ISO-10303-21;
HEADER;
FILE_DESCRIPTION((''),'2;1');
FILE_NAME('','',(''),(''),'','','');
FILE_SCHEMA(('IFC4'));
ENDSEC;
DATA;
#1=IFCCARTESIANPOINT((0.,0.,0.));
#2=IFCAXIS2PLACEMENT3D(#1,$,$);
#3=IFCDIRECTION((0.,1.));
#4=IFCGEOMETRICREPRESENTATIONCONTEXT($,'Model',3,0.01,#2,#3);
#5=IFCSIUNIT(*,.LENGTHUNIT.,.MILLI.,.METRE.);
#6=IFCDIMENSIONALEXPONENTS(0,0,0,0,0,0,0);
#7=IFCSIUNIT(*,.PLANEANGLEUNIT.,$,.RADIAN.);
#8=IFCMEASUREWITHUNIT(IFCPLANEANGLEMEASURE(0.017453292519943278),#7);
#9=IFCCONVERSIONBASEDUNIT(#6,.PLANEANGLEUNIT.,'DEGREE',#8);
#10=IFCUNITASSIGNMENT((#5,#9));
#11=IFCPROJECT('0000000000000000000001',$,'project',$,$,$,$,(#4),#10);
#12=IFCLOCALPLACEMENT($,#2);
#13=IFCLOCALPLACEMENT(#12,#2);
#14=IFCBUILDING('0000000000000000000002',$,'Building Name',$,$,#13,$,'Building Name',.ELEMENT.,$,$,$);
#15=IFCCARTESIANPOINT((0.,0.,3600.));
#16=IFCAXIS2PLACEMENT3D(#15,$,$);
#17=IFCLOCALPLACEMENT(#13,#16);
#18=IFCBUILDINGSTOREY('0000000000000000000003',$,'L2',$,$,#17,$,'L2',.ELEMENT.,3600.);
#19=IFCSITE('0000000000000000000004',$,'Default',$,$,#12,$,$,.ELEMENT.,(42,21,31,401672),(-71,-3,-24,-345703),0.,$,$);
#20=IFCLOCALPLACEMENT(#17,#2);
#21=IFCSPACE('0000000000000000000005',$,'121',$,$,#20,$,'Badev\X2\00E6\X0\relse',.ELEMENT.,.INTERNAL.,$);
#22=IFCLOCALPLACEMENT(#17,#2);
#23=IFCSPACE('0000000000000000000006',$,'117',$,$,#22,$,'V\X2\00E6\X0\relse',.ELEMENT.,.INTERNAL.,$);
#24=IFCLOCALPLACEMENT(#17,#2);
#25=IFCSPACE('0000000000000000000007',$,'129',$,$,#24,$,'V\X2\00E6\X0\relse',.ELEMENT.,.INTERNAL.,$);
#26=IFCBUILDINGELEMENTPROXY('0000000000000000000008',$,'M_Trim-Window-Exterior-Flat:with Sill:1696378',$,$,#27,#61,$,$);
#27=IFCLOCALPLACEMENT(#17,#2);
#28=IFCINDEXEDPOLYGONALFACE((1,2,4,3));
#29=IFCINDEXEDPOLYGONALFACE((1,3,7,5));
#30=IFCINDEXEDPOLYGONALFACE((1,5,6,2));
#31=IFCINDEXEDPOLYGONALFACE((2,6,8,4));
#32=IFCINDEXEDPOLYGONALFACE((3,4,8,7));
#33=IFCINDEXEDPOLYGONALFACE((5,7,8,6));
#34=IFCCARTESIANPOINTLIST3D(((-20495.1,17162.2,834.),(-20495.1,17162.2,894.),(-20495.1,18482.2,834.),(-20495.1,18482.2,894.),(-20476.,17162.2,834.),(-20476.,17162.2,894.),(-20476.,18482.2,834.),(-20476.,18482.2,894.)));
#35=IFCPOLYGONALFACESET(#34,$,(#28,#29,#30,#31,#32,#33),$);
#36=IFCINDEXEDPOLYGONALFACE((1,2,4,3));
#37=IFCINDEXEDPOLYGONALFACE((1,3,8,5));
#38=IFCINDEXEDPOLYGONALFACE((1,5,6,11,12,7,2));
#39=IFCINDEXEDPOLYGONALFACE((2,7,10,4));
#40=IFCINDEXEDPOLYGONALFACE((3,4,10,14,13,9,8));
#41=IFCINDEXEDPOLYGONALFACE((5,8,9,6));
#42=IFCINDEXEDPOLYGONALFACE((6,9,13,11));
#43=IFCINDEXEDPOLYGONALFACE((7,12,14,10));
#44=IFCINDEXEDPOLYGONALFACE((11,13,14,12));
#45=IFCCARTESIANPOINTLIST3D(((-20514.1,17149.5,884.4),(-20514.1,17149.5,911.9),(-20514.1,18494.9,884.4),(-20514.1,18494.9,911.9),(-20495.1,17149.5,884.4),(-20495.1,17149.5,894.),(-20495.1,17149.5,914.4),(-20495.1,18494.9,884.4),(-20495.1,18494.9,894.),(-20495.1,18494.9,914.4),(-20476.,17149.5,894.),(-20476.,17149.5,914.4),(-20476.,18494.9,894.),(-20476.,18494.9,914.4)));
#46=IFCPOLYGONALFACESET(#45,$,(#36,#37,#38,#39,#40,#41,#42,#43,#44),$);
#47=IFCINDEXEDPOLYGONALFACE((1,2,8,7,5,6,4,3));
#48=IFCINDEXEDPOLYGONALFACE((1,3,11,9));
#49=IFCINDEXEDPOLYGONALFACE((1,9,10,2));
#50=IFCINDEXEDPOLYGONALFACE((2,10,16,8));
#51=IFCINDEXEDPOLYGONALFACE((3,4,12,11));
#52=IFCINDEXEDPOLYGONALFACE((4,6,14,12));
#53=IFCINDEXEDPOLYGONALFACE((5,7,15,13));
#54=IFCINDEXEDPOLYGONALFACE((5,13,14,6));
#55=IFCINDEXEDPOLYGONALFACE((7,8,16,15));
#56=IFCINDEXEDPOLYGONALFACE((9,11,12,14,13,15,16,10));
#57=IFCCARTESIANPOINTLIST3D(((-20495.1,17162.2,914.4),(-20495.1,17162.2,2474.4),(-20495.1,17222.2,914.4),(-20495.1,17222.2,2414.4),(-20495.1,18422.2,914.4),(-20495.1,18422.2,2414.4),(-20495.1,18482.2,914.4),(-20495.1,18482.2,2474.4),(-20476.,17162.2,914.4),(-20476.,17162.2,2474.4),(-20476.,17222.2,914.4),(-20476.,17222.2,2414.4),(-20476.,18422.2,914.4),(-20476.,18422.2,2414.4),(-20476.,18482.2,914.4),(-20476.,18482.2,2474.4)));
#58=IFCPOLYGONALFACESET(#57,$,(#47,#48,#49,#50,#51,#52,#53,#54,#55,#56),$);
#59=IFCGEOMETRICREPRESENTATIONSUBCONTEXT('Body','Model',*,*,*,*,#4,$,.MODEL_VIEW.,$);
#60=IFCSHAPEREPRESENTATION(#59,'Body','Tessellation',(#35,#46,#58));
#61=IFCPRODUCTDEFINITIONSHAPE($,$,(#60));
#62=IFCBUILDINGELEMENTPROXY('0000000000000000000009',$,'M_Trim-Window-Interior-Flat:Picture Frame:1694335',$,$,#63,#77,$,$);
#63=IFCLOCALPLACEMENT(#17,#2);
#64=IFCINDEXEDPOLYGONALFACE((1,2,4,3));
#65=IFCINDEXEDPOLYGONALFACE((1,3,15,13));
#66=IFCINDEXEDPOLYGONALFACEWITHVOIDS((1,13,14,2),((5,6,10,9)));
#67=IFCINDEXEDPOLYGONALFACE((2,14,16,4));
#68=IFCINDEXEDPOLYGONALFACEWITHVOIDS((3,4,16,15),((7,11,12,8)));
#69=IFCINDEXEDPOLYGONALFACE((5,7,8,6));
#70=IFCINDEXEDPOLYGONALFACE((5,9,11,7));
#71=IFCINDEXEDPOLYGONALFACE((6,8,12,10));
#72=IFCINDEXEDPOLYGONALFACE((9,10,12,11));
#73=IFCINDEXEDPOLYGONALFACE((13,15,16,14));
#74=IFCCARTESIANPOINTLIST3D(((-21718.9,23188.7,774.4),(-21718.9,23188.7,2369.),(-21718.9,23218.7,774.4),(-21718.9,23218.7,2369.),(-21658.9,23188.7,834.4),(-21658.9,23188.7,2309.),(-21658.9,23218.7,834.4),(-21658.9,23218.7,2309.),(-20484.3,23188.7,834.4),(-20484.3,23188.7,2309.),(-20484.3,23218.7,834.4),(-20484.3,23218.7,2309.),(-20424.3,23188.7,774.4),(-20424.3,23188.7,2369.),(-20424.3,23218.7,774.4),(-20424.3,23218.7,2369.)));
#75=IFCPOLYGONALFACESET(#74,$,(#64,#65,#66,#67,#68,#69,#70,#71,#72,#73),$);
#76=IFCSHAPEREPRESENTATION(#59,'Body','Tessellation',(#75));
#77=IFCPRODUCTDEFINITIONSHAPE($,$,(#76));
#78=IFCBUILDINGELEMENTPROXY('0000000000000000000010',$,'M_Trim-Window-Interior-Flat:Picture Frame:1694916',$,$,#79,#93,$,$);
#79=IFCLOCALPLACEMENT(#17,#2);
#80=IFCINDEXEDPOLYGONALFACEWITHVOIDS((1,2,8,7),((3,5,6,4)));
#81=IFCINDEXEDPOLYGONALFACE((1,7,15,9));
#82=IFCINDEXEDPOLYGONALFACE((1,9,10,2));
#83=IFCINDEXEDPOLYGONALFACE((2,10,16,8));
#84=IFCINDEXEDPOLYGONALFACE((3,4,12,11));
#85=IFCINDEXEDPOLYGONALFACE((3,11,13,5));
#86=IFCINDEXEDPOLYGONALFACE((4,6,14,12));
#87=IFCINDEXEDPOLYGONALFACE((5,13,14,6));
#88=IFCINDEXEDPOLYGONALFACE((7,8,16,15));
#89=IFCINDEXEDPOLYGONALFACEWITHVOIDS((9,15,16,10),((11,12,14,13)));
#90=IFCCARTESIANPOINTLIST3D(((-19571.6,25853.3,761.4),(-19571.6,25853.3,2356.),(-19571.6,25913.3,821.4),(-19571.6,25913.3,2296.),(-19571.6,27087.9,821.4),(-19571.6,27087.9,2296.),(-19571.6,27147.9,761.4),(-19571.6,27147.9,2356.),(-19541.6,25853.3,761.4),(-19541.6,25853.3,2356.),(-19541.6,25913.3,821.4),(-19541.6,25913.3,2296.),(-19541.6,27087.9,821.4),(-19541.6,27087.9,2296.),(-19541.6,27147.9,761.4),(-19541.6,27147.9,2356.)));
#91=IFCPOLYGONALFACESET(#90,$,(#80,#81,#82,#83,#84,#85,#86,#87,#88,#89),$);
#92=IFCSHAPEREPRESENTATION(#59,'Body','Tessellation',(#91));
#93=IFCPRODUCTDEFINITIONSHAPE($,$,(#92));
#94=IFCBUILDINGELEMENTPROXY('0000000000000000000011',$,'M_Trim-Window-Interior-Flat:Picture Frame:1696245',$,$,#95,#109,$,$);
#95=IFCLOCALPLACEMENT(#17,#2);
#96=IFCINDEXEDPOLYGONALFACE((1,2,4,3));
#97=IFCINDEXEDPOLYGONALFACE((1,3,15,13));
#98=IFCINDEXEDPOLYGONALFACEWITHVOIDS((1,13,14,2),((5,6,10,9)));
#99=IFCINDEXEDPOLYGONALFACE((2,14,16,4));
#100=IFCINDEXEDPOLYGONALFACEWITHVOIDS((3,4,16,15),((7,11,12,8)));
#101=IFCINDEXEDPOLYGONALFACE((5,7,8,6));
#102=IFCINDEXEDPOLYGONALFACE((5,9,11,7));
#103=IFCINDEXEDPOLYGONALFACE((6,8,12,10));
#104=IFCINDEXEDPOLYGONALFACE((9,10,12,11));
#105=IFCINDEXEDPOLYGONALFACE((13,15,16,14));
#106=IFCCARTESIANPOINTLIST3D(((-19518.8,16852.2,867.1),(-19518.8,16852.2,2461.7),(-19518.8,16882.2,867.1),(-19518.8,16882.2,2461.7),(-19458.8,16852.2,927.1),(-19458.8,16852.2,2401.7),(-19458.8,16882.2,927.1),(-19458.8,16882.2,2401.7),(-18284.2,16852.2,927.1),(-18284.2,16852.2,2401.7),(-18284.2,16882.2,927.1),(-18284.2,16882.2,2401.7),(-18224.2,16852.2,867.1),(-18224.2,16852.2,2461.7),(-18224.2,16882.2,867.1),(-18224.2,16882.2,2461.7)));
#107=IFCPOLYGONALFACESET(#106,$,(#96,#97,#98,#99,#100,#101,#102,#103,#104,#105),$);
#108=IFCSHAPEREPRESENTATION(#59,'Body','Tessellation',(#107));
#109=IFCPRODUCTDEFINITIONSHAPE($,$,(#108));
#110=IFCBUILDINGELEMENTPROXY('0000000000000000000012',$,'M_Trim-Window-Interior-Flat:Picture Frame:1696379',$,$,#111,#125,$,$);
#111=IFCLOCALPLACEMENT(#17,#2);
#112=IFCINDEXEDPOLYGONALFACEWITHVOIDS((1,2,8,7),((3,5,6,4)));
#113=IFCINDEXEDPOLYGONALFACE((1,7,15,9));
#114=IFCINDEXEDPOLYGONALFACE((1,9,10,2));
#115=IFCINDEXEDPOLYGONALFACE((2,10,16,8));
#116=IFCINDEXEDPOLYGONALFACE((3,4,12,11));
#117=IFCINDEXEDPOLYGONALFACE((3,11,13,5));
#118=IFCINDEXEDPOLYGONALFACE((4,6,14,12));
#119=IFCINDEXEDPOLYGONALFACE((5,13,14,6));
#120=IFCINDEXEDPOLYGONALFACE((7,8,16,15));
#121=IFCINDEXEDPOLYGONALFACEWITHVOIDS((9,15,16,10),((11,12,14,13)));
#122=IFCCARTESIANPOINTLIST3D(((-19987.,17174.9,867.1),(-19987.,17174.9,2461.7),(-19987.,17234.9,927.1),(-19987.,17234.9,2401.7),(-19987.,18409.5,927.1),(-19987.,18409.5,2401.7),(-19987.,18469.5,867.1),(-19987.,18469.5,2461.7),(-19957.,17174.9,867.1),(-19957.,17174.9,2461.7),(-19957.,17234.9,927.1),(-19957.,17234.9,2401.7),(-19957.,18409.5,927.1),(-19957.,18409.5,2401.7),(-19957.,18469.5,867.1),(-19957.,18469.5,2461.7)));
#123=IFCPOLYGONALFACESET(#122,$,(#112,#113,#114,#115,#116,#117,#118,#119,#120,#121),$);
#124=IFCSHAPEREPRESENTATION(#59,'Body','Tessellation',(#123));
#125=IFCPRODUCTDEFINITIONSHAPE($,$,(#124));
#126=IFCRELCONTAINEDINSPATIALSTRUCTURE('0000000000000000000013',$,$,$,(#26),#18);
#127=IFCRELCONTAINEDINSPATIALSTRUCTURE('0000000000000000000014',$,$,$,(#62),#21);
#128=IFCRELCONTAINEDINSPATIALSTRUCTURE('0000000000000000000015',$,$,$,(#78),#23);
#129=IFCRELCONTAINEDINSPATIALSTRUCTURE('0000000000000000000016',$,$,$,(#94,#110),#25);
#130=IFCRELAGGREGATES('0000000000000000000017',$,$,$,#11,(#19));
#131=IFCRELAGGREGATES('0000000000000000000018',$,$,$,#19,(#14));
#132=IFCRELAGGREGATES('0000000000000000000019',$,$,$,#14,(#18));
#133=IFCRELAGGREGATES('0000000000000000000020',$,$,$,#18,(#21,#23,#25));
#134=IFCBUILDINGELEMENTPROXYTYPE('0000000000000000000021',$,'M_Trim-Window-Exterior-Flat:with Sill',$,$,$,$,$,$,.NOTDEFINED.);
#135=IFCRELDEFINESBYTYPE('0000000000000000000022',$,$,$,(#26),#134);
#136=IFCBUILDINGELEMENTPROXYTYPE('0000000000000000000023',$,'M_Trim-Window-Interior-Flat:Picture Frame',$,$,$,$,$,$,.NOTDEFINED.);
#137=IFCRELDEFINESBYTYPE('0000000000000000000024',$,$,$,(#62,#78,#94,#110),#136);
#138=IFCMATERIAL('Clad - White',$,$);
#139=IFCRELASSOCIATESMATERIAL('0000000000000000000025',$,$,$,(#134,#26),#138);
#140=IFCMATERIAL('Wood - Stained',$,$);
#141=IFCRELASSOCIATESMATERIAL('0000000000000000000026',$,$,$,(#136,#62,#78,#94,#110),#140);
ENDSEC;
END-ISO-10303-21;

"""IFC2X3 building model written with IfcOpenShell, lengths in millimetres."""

from ifc_helpers import new_model, entity, si_unit, converted_unit, direction, frame, frame_2d, origin, place, context, subcontext, project, spatial, polyline, rectangle, outline, extrude, source, transform, mapped, material, type_object, type_shapes, element, save


model = new_model("IFC2X3")

# Units and contexts
model_context = context("Model", 3, precision=0.01, world=origin(), true_north=direction((0.0, 1.0)))
body_context = subcontext(model_context, "Body", "Model", "MODEL_VIEW")
ifc_project = project(units=[si_unit("LENGTHUNIT", "METRE", prefix="MILLI"), converted_unit("PLANEANGLEUNIT", "DEGREE", entity("IfcPlaneAngleMeasure", 0.017453292519943278), si_unit("PLANEANGLEUNIT", "RADIAN"), dimensions=[0, 0, 0, 0, 0, 0, 0])], contexts=[model_context])

# Site, building, storey
site_placement = place(None, origin())
site = spatial("IfcSite", under=ifc_project, at=site_placement, Name="Default", CompositionType="ELEMENT", RefLatitude=(42, 21, 31, 401672), RefLongitude=(-71, -3, -24, -345703), RefElevation=0.0)
building_placement = place(site_placement, origin())
building = spatial("IfcBuilding", under=site, at=building_placement, Name="Building Name", LongName="Building Name", CompositionType="ELEMENT")
storey_placement = place(building_placement, frame((0.0, 0.0, 3600.0)))
storey = spatial("IfcBuildingStorey", under=building, at=storey_placement, Name="L2", LongName="L2", CompositionType="ELEMENT", Elevation=3600.0)

# Shared definitions
ifc_material_1 = material(Name="Wood - Stained")

# Building element proxy
ifc_material_2 = material(Name="Clad - White")
building_element_proxy_type_1 = type_object("IfcBuildingElementProxyType", Name="M_Trim-Window-Exterior-Flat:with Sill", PredefinedType="NOTDEFINED", material=ifc_material_2)
shared_shape_1 = source(origin(), body_context, "Body", "SweptSolid", [
    extrude(rectangle(XDim=1320.0, YDim=60.0, at=frame_2d((0.0, 0.0), x_axis=(1.0, 0.0))), frame((0.0, -1550.4, 0.0), z_axis=(0.0, 0.0, 1.0), x_axis=(-1.0, 0.0, 0.0)), (0.0, 0.0, 1.0), 19.0),
    extrude(outline(polyline([(-19.0, -15.2), (0.0, -15.2), (0.0, -5.7), (19.0, -5.7), (19.0, 14.8), (0.0, 14.8), (-19.0, 12.3), (-19.0, -15.2)])), frame((-672.7, -1514.8, 19.0), z_axis=(1.0, 0.0, 0.0), x_axis=(0.0, 0.0, -1.0)), (0.0, 0.0, 1.0), 1345.4),
    extrude(outline(polyline([(-795.0, -660.0), (765.0, -660.0), (765.0, -600.0), (-735.0, -600.0), (-735.0, 600.0), (765.0, 600.0), (765.0, 660.0), (-795.0, 660.0), (-795.0, -660.0)])), frame((0.0, -735.0, 0.0), z_axis=(0.0, 0.0, 1.0), x_axis=(0.0, -1.0, 0.0)), (0.0, 0.0, 1.0), 19.0),
])
type_shapes(building_element_proxy_type_1, [shared_shape_1])
for number, where, z_axis, x_axis, name in (
    (1, (-20476.0, 17822.2, 2414.4), (-1.0, 0.0, 0.0), (0.0, -1.0, 0.0), "M_Trim-Window-Exterior-Flat:with Sill:1696378"),
):
    element("IfcBuildingElementProxy", number, at=place(storey_placement, frame(where, z_axis=z_axis, x_axis=x_axis)), inside=storey, type_object=building_element_proxy_type_1, material=ifc_material_2, Name=name, context=body_context, shape_type="MappedRepresentation", body=[
        mapped(shared_shape_1, transform((0.0, 0.0, 0.0), scale=1.0)),
    ])

# Shared definitions
space_1_placement = place(storey_placement, origin())
space_1 = spatial("IfcSpace", under=storey, at=space_1_placement, Name="121", LongName="Badeværelse", CompositionType="ELEMENT", InteriorOrExteriorSpace="INTERNAL")

# Building element proxy
building_element_proxy_type_2 = type_object("IfcBuildingElementProxyType", Name="M_Trim-Window-Interior-Flat:Picture Frame", PredefinedType="NOTDEFINED", material=ifc_material_1)
shared_shape_2 = source(origin(), body_context, "Body", "SweptSolid", [
    extrude(outline(polyline([(-647.3, -797.3), (647.3, -797.3), (647.3, 797.3), (-647.3, 797.3), (-647.3, -797.3)]), holes=[polyline([(-587.3, -737.3), (-587.3, 737.3), (587.3, 737.3), (587.3, -737.3), (-587.3, -737.3)])]), frame((0.0, -750.0, 0.0), z_axis=(0.0, 0.0, 1.0), x_axis=(-1.0, 0.0, 0.0)), (0.0, 0.0, 1.0), 30.0),
])
type_shapes(building_element_proxy_type_2, [shared_shape_2])
proxy_1_placement = place(space_1_placement, frame((-21071.6, 23218.7, 2321.7), z_axis=(0.0, -1.0, 0.0), x_axis=(1.0, 0.0, 0.0)))
element("IfcBuildingElementProxy", 2, at=proxy_1_placement, inside=space_1, type_object=building_element_proxy_type_2, material=ifc_material_1, Name="M_Trim-Window-Interior-Flat:Picture Frame:1694335", context=body_context, shape_type="MappedRepresentation", body=[
    mapped(shared_shape_2, transform((0.0, 0.0, 0.0), scale=1.0)),
])

# Shared definitions
space_2_placement = place(storey_placement, origin())
space_2 = spatial("IfcSpace", under=storey, at=space_2_placement, Name="117", LongName="Værelse", CompositionType="ELEMENT", InteriorOrExteriorSpace="INTERNAL")

# Building element proxy
proxy_2_placement = place(space_2_placement, frame((-19571.6, 26500.6, 2308.7), z_axis=(1.0, 0.0, 0.0), x_axis=(0.0, 1.0, 0.0)))
element("IfcBuildingElementProxy", 3, at=proxy_2_placement, inside=space_2, type_object=building_element_proxy_type_2, material=ifc_material_1, Name="M_Trim-Window-Interior-Flat:Picture Frame:1694916", context=body_context, shape_type="MappedRepresentation", body=[
    mapped(shared_shape_2, transform((0.0, 0.0, 0.0), scale=1.0)),
])

# Shared definitions
space_3_placement = place(storey_placement, origin())
space_3 = spatial("IfcSpace", under=storey, at=space_3_placement, Name="129", LongName="Værelse", CompositionType="ELEMENT", InteriorOrExteriorSpace="INTERNAL")

# Building element proxies
for number, where, z_axis, x_axis, name in (
    (4, (-18871.5, 16852.2, 2414.4), (0.0, 1.0, 0.0), (-1.0, 0.0, 0.0), "M_Trim-Window-Interior-Flat:Picture Frame:1696245"),
    (5, (-19987.0, 17822.2, 2414.4), (1.0, 0.0, 0.0), (0.0, 1.0, 0.0), "M_Trim-Window-Interior-Flat:Picture Frame:1696379"),
):
    element("IfcBuildingElementProxy", number, at=place(space_3_placement, frame(where, z_axis=z_axis, x_axis=x_axis)), inside=space_3, type_object=building_element_proxy_type_2, material=ifc_material_1, Name=name, context=body_context, shape_type="MappedRepresentation", body=[
        mapped(shared_shape_2, transform((0.0, 0.0, 0.0), scale=1.0)),
    ])

save(model, "model.ifc")
